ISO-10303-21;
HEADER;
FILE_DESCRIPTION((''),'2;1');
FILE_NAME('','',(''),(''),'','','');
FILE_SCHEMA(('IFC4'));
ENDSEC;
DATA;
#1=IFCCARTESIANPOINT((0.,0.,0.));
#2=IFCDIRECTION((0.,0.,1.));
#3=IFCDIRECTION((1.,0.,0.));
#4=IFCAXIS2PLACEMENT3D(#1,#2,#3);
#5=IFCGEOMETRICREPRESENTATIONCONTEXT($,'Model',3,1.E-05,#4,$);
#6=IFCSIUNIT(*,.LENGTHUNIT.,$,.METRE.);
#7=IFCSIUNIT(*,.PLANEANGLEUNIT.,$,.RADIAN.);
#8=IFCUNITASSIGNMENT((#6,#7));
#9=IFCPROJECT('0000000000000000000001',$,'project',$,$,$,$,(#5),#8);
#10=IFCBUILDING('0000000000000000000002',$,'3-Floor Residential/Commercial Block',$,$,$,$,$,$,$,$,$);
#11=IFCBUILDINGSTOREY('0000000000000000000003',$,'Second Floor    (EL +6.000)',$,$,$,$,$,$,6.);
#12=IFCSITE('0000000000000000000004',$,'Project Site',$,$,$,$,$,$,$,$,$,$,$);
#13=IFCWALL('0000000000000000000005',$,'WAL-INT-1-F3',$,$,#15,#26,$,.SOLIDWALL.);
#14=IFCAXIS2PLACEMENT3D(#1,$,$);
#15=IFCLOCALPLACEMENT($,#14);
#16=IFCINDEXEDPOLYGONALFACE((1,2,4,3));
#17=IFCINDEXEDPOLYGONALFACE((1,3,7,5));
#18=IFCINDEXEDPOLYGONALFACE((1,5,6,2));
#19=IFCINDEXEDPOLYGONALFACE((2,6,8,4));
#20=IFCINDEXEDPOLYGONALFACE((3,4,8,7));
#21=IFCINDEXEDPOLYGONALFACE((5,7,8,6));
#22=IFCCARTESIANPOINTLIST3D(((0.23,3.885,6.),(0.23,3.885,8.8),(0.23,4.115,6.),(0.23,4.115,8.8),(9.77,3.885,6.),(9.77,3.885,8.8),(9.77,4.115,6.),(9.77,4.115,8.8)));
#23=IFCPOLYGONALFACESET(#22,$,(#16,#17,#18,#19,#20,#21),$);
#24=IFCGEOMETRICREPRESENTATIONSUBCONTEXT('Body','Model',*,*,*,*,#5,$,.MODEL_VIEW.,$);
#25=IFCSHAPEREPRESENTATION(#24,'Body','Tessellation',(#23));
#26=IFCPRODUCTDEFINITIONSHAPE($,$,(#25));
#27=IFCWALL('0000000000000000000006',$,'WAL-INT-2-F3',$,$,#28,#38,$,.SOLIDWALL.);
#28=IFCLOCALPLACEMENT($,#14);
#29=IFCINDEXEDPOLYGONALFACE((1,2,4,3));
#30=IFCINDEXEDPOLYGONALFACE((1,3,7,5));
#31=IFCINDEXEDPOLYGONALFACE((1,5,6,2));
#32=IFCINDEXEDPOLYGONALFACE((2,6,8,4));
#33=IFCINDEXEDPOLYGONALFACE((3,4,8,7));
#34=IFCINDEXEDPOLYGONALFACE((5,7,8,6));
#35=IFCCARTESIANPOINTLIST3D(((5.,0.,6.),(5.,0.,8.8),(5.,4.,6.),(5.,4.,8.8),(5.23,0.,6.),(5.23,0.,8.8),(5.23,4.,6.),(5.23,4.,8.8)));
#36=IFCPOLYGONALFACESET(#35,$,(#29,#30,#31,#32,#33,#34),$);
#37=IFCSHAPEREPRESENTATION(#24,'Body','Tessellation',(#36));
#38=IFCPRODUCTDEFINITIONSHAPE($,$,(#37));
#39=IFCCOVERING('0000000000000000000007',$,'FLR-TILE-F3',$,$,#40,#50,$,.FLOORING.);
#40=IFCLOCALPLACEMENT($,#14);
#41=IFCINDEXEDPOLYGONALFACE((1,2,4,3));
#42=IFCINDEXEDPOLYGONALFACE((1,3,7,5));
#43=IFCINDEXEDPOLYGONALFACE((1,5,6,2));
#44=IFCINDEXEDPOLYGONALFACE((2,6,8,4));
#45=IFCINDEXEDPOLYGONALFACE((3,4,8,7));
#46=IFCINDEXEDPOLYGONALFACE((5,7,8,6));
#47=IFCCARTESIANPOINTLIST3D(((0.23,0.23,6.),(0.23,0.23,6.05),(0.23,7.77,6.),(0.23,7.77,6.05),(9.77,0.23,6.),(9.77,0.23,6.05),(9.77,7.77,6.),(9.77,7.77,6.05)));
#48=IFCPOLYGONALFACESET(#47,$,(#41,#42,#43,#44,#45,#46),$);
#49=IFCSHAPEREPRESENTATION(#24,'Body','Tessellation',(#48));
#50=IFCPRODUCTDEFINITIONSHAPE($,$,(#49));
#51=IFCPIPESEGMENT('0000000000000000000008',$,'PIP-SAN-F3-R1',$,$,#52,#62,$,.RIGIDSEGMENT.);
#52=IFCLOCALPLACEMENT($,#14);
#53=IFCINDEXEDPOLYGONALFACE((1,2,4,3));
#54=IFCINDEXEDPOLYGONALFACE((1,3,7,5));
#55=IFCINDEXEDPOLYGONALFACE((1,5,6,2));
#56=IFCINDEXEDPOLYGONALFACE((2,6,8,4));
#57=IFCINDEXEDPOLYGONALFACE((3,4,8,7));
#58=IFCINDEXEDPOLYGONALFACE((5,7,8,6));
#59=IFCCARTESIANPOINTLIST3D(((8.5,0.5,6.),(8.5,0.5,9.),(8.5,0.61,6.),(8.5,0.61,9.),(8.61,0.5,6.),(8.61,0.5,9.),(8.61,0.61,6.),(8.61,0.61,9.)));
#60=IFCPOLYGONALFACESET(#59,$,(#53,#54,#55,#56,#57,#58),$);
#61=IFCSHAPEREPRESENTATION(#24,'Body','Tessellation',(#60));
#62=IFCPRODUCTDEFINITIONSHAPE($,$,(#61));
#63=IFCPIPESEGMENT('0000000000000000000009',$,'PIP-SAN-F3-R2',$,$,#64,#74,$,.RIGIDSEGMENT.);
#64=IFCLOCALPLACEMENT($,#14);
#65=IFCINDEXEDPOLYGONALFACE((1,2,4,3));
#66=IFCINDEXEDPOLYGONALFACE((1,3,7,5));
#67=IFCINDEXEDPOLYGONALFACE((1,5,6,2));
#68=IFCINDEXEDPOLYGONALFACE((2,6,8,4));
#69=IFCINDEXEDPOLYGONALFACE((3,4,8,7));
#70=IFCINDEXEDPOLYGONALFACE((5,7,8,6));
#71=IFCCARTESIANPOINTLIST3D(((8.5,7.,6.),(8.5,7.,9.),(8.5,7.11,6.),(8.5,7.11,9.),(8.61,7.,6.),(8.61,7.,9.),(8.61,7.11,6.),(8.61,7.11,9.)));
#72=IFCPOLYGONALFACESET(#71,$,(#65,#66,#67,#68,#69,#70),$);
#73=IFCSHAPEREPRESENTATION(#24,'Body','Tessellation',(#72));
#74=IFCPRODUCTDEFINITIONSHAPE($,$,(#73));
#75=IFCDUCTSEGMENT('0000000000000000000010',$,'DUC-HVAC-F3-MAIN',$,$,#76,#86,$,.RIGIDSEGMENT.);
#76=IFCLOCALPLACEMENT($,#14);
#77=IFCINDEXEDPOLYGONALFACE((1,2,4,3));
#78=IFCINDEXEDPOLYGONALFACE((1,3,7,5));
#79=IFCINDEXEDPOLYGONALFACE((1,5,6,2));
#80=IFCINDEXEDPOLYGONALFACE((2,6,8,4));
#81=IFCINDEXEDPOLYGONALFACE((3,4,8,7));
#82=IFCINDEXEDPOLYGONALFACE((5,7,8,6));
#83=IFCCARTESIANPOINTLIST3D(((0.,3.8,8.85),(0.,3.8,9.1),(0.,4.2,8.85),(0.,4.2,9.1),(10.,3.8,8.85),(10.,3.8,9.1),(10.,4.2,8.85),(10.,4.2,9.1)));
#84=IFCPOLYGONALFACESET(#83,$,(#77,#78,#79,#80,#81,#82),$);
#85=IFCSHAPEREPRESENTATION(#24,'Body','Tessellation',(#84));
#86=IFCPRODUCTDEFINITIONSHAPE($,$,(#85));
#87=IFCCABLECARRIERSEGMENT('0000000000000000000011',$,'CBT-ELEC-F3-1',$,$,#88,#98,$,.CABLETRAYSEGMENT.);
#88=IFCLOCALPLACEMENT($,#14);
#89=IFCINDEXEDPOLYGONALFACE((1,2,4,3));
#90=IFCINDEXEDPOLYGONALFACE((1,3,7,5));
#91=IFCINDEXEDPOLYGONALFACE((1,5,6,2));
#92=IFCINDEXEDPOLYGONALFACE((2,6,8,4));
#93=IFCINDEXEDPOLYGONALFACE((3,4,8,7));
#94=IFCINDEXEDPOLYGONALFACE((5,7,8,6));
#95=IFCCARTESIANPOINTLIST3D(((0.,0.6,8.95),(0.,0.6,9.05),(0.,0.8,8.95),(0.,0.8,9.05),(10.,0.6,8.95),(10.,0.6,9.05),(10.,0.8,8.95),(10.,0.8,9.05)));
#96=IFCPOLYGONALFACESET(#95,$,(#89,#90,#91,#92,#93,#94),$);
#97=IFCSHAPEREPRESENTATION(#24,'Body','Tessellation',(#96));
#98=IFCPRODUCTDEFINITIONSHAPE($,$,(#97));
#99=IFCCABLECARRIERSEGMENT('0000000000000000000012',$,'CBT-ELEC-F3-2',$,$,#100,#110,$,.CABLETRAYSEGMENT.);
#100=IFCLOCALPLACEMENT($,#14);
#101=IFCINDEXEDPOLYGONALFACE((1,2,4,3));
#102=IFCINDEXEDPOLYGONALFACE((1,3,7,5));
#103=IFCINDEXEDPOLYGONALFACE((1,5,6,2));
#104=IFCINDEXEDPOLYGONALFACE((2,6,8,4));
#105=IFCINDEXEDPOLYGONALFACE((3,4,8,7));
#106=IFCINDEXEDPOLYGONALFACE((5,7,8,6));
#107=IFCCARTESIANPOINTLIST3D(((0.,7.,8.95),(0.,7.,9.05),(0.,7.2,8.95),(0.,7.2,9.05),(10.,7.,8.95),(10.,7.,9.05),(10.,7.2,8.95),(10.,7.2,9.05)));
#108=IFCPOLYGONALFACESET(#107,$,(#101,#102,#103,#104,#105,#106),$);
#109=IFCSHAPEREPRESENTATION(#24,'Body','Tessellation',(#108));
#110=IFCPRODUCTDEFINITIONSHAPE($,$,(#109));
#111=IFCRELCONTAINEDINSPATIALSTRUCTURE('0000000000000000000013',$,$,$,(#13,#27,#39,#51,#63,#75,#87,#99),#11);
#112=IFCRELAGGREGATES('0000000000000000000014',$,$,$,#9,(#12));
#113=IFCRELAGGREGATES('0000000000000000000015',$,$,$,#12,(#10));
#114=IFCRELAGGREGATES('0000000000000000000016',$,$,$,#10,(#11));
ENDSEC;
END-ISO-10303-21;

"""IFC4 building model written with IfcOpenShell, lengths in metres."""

from ifc_helpers import new_model, si_unit, frame, frame_2d, origin_with_axes, place, context, subcontext, project, spatial, rectangle, extrude, element, save


model = new_model("IFC4")

# Units and contexts
model_context = context("Model", 3, precision=1e-05, world=origin_with_axes())
body_context = subcontext(model_context, "Body", "Model", "MODEL_VIEW")
ifc_project = project(units=[si_unit("LENGTHUNIT", "METRE"), si_unit("PLANEANGLEUNIT", "RADIAN")], contexts=[model_context])

# Site, building, storey
site = spatial("IfcSite", under=ifc_project, Name="Project Site")
building = spatial("IfcBuilding", under=site, Name="3-Floor Residential/Commercial Block")
storey = spatial("IfcBuildingStorey", under=building, Name="Second Floor    (EL +6.000)", Elevation=6.0)

# Walls
wall_1_placement = place(None, frame((0.23, 3.885, 6.0), z_axis=(0.0, 0.0, 1.0), x_axis=(1.0, 0.0, 0.0)))
element("IfcWall", 1, at=wall_1_placement, inside=storey, Name="WAL-INT-1-F3", PredefinedType="SOLIDWALL", context=body_context, shape_type="SweptSolid", body=[
    extrude(rectangle(XDim=9.54, YDim=0.23, at=frame_2d((4.77, 0.115))), origin_with_axes(), (0.0, 0.0, 1.0), 2.8),
])
wall_2_placement = place(None, frame((5.0, 0.0, 6.0), z_axis=(0.0, 0.0, 1.0), x_axis=(1.0, 0.0, 0.0)))
element("IfcWall", 2, at=wall_2_placement, inside=storey, Name="WAL-INT-2-F3", PredefinedType="SOLIDWALL", context=body_context, shape_type="SweptSolid", body=[
    extrude(rectangle(XDim=0.23, YDim=4.0, at=frame_2d((0.115, 2.0))), origin_with_axes(), (0.0, 0.0, 1.0), 2.8),
])

# Covering
covering_placement = place(None, frame((0.23, 0.23, 6.0), z_axis=(0.0, 0.0, 1.0), x_axis=(1.0, 0.0, 0.0)))
element("IfcCovering", 3, at=covering_placement, inside=storey, Name="FLR-TILE-F3", PredefinedType="FLOORING", context=body_context, shape_type="SweptSolid", body=[
    extrude(rectangle(XDim=9.54, YDim=7.54, at=frame_2d((4.77, 3.77))), origin_with_axes(), (0.0, 0.0, 1.0), 0.05),
])

# Pipe segments
for number, where, z_axis, x_axis, name in (
    (4, (8.5, 0.5, 6.0), (0.0, 0.0, 1.0), (1.0, 0.0, 0.0), "PIP-SAN-F3-R1"),
    (5, (8.5, 7.0, 6.0), (0.0, 0.0, 1.0), (1.0, 0.0, 0.0), "PIP-SAN-F3-R2"),
):
    element("IfcPipeSegment", number, at=place(None, frame(where, z_axis=z_axis, x_axis=x_axis)), inside=storey, Name=name, PredefinedType="RIGIDSEGMENT", context=body_context, shape_type="SweptSolid", body=[
        extrude(rectangle(XDim=0.11, YDim=0.11, at=frame_2d((0.055, 0.055))), origin_with_axes(), (0.0, 0.0, 1.0), 3.0),
    ])

# Duct segment
duct_segment_placement = place(None, frame((0.0, 3.8, 8.85), z_axis=(0.0, 0.0, 1.0), x_axis=(1.0, 0.0, 0.0)))
element("IfcDuctSegment", 6, at=duct_segment_placement, inside=storey, Name="DUC-HVAC-F3-MAIN", PredefinedType="RIGIDSEGMENT", context=body_context, shape_type="SweptSolid", body=[
    extrude(rectangle(XDim=10.0, YDim=0.4, at=frame_2d((5.0, 0.2))), origin_with_axes(), (0.0, 0.0, 1.0), 0.25),
])

# Cable carrier segments
for number, where, z_axis, x_axis, name in (
    (7, (0.0, 0.6, 8.95), (0.0, 0.0, 1.0), (1.0, 0.0, 0.0), "CBT-ELEC-F3-1"),
    (8, (0.0, 7.0, 8.95), (0.0, 0.0, 1.0), (1.0, 0.0, 0.0), "CBT-ELEC-F3-2"),
):
    element("IfcCableCarrierSegment", number, at=place(None, frame(where, z_axis=z_axis, x_axis=x_axis)), inside=storey, Name=name, PredefinedType="CABLETRAYSEGMENT", context=body_context, shape_type="SweptSolid", body=[
        extrude(rectangle(XDim=10.0, YDim=0.2, at=frame_2d((5.0, 0.1))), origin_with_axes(), (0.0, 0.0, 1.0), 0.1),
    ])

save(model, "model.ifc")
